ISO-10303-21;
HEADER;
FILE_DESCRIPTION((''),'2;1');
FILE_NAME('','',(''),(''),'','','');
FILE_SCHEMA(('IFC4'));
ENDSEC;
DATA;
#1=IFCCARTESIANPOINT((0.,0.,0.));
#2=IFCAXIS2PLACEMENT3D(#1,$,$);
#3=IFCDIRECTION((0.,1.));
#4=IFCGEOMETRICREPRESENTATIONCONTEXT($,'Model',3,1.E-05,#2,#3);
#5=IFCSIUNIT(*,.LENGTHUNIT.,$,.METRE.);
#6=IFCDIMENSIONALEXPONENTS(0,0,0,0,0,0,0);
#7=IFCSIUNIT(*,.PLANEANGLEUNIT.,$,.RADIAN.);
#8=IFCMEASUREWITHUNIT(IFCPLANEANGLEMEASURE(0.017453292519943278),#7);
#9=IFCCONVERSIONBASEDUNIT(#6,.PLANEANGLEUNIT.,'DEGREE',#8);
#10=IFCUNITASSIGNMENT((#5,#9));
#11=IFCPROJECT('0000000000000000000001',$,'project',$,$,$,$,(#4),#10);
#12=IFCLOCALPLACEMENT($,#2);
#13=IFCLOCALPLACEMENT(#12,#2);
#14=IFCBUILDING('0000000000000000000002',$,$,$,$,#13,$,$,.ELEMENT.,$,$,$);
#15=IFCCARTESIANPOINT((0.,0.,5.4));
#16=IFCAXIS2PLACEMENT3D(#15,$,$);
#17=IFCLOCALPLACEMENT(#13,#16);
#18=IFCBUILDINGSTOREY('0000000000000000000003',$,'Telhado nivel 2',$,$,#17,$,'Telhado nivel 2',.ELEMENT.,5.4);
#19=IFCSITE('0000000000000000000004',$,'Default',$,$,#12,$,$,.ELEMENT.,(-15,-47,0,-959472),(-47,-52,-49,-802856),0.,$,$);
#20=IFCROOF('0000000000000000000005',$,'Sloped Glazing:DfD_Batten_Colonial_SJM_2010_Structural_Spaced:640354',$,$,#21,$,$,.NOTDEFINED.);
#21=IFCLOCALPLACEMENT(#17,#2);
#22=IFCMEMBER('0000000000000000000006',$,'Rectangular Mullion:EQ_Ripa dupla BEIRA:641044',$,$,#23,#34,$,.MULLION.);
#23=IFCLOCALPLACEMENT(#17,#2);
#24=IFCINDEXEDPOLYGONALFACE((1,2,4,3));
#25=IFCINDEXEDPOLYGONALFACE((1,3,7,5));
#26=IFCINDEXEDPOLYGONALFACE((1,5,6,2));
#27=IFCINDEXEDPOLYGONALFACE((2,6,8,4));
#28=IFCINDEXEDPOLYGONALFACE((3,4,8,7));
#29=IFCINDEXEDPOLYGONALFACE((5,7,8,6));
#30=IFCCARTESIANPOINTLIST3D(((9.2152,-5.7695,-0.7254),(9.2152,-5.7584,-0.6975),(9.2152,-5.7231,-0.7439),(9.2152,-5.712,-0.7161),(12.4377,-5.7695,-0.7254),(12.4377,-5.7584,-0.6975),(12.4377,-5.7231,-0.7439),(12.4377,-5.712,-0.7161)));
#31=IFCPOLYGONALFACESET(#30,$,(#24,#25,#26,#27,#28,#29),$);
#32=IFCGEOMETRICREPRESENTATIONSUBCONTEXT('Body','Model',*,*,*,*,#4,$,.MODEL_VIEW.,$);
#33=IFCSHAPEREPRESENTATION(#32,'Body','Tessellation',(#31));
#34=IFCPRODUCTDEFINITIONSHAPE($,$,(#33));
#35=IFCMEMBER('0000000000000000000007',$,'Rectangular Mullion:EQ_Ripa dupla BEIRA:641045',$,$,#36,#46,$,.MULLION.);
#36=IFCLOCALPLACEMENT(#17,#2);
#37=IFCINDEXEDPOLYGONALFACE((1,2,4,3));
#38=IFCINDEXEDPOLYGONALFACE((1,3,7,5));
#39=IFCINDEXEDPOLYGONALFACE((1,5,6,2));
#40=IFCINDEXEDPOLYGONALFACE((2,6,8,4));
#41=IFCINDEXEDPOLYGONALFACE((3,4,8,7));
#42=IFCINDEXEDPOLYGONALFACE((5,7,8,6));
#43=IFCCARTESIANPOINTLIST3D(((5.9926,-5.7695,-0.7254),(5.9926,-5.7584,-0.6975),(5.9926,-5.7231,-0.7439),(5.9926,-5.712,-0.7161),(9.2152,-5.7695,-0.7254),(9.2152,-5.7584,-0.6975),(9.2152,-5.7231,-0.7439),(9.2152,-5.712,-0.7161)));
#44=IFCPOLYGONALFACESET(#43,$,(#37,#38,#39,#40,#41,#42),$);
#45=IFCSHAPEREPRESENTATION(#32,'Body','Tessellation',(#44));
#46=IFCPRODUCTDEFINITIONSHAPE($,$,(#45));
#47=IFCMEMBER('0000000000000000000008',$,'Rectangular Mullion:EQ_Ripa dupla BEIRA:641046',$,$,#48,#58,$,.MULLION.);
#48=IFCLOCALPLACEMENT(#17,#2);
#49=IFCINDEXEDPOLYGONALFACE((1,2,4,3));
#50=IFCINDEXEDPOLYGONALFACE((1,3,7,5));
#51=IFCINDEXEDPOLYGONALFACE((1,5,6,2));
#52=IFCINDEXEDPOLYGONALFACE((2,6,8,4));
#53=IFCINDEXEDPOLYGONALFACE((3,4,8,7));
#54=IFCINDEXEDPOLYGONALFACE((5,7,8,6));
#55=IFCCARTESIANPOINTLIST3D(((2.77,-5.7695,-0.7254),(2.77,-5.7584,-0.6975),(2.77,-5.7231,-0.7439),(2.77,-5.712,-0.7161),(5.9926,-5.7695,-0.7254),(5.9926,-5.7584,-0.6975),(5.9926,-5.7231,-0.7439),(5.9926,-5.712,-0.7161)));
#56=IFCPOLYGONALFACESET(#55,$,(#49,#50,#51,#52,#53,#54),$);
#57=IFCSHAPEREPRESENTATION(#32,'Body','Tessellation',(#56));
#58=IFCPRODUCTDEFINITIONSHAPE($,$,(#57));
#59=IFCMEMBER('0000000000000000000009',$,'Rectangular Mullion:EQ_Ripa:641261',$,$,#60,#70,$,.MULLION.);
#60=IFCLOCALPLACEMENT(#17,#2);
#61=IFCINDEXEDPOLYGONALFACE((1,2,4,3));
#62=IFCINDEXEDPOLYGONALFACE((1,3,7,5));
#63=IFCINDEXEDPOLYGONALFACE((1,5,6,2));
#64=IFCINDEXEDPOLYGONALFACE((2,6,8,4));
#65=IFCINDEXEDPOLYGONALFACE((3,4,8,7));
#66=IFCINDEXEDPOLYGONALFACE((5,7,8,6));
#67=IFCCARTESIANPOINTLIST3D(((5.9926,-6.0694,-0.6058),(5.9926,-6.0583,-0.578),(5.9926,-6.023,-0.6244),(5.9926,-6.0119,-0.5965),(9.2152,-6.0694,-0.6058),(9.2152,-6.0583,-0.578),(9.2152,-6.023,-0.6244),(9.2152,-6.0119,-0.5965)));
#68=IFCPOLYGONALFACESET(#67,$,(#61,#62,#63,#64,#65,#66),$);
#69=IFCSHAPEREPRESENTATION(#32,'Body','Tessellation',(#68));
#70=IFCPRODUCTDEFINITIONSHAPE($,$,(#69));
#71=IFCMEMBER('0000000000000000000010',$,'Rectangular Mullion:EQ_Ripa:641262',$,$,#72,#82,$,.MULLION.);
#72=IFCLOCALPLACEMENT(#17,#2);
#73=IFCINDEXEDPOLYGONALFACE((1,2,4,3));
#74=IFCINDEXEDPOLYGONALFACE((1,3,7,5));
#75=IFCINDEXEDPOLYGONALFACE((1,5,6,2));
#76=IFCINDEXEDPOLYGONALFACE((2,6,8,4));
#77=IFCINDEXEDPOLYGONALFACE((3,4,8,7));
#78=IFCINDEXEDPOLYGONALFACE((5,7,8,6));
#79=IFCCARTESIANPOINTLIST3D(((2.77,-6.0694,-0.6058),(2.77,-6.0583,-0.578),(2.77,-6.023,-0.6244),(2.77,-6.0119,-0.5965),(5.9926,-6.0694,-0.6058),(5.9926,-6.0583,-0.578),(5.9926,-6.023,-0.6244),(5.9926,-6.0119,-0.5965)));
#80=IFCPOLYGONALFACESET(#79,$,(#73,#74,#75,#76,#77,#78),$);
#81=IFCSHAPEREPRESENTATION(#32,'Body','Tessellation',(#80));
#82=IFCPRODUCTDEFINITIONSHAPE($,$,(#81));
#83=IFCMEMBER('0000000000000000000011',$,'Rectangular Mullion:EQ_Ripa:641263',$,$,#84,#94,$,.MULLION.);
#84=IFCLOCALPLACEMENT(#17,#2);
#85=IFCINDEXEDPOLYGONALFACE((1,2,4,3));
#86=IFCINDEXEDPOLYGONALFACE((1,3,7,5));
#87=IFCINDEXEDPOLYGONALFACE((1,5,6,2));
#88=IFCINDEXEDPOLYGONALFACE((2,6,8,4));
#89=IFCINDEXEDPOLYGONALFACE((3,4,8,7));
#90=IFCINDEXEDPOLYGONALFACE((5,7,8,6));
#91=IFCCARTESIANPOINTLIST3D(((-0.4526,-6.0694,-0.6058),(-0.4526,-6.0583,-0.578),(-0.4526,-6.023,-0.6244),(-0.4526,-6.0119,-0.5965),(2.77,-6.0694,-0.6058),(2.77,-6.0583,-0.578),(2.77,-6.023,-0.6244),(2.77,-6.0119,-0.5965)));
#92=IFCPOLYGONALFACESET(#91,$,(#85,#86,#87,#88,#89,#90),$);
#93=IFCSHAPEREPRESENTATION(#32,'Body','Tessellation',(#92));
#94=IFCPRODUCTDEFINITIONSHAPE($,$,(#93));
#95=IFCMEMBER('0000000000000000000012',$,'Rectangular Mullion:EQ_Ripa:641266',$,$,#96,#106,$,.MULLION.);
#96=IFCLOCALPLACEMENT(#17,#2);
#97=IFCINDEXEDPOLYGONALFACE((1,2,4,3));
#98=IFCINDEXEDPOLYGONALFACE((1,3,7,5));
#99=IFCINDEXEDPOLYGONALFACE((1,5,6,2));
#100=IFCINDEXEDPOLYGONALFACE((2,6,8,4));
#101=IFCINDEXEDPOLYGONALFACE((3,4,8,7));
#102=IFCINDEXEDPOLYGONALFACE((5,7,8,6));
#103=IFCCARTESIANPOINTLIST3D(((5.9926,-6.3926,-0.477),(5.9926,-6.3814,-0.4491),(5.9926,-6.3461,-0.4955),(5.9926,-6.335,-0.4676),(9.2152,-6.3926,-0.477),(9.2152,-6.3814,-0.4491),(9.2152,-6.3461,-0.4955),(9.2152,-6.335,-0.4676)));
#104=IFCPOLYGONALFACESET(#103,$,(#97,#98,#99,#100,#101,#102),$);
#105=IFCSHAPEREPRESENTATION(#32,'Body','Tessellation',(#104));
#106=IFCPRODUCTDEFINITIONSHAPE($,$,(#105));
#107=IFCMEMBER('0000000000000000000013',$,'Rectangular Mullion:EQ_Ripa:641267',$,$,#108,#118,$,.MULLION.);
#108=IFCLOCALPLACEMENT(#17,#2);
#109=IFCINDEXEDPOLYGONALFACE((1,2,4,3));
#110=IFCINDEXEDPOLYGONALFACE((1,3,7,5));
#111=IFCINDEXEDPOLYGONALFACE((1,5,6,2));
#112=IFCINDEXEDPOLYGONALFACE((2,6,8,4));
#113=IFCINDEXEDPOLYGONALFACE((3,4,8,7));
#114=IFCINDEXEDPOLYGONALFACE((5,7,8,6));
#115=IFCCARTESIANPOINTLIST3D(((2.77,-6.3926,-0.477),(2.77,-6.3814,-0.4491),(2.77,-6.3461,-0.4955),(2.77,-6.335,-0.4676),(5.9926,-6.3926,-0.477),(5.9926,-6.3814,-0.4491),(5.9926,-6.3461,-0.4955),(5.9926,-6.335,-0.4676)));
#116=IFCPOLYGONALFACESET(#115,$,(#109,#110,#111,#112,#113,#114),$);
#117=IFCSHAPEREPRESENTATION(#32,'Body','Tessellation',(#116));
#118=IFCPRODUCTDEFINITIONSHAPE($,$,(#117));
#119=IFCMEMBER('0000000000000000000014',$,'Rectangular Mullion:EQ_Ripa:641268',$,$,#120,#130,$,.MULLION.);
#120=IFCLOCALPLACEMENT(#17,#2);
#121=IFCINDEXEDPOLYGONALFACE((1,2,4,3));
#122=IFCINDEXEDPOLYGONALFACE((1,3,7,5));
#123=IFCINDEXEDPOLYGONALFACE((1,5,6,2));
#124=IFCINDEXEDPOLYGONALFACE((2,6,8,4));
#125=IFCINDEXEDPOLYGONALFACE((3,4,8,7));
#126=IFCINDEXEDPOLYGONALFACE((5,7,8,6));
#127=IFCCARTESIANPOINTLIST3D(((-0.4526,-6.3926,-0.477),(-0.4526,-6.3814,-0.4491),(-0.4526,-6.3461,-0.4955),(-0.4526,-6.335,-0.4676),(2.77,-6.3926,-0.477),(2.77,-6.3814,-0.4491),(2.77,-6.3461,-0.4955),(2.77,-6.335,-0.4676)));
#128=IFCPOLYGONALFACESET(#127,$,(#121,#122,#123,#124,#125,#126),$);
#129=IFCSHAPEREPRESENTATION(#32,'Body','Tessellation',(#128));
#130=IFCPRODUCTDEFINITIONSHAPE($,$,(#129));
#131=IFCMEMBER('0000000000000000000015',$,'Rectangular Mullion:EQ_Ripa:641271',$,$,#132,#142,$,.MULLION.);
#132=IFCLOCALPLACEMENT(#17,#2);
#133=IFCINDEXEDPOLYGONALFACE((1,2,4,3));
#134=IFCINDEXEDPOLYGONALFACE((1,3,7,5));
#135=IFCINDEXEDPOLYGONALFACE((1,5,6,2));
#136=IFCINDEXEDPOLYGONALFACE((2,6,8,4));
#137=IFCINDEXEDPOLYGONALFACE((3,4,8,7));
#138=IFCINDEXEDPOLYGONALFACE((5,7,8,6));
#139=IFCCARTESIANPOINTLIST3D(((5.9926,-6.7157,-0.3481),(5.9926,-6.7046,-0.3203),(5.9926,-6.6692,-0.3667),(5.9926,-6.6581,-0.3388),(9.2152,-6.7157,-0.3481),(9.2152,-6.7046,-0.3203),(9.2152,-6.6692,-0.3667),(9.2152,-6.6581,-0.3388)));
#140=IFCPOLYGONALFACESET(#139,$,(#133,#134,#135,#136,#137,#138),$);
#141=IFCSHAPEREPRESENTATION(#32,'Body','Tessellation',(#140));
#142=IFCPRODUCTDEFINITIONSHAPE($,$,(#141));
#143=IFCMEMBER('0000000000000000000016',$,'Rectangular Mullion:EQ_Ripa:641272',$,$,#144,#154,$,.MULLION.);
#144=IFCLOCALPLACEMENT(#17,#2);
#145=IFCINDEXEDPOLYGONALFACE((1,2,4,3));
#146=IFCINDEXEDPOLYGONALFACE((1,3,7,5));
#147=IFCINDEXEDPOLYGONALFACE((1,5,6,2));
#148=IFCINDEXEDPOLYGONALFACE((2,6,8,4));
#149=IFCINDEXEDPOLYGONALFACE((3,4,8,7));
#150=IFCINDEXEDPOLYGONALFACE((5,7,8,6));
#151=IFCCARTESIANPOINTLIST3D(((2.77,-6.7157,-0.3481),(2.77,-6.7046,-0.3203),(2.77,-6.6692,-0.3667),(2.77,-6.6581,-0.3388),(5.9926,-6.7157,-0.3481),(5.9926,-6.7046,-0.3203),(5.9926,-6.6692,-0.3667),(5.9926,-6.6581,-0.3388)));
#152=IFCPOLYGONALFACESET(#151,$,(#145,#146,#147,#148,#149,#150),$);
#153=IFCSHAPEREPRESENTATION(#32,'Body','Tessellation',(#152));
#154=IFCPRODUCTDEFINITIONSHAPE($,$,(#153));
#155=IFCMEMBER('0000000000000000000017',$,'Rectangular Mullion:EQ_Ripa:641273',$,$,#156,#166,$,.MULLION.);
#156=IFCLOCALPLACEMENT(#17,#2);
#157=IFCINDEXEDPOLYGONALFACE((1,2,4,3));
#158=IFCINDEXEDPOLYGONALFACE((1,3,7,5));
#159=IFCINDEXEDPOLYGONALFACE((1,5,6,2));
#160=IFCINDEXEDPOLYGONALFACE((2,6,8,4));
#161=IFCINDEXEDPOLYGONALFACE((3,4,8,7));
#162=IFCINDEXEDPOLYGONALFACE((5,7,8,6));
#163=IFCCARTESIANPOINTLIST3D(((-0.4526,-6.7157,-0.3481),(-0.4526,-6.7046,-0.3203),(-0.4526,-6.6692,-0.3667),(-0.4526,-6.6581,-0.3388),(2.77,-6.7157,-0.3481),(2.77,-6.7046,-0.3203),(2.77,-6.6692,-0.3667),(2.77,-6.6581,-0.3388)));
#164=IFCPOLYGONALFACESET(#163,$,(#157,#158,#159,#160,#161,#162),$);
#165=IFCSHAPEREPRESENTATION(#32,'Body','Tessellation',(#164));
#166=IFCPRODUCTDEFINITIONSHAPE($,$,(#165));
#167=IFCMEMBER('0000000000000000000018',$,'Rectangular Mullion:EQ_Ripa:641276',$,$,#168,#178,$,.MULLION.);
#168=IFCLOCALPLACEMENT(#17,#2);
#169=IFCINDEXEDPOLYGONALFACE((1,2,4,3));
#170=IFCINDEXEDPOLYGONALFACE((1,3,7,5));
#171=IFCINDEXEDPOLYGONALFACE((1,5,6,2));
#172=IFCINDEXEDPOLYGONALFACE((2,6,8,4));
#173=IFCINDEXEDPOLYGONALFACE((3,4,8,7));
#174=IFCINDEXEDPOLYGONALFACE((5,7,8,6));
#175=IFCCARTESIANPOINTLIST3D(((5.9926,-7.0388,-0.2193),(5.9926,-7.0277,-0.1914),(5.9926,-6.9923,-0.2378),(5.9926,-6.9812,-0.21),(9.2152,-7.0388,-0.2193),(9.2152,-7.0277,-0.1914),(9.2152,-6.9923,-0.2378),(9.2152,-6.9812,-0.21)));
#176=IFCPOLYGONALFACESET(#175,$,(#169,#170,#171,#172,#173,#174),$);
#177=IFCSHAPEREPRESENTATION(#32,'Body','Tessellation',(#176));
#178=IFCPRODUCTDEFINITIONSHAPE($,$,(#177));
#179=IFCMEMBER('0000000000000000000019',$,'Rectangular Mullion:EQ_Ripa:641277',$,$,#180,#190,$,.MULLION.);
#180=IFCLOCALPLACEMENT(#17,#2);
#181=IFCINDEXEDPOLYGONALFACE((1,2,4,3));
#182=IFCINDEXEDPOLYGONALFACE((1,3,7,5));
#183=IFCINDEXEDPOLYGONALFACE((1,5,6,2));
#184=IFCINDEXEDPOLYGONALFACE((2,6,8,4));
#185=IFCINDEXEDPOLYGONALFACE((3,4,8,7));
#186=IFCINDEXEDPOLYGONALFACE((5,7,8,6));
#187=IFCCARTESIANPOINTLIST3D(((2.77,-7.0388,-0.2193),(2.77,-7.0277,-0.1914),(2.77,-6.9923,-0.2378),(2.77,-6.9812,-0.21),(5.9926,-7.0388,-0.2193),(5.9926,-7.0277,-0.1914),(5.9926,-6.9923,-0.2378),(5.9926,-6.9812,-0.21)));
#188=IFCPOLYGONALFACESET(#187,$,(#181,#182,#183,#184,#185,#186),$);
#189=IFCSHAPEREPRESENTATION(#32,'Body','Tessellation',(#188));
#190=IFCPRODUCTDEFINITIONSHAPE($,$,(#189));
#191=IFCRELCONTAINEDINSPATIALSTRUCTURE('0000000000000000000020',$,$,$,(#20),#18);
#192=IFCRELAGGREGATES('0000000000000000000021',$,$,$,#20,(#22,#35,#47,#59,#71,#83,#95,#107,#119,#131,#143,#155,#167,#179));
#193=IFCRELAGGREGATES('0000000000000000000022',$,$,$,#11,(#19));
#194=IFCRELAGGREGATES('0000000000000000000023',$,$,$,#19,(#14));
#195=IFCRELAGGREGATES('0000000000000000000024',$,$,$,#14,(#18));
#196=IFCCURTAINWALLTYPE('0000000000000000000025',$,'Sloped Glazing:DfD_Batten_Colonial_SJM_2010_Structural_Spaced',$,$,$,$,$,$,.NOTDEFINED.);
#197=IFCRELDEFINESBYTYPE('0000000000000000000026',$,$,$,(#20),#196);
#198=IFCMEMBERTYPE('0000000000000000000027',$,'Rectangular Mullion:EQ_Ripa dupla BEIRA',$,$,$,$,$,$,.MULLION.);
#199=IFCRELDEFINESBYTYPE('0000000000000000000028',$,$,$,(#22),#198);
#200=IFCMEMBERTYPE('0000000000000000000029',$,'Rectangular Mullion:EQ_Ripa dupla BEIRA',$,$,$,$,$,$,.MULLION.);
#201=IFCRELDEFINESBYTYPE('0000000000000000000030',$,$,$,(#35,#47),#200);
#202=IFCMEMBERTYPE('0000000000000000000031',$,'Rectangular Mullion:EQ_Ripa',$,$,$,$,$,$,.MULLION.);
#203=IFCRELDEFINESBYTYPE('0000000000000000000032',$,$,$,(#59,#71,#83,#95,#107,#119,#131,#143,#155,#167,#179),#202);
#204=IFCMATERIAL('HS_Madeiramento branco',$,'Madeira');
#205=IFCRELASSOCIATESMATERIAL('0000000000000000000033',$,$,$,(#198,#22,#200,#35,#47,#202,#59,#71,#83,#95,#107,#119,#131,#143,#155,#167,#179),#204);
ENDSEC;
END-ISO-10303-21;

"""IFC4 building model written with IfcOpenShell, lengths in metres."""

from ifc_helpers import new_model, entity, si_unit, converted_unit, direction, frame, origin, place, context, subcontext, project, spatial, indexed_curve, outline, extrude, source, transform, mapped, material, type_object, type_shapes, element, aggregate, save


model = new_model("IFC4")

# Units and contexts
model_context = context("Model", 3, precision=1e-05, world=origin(), true_north=direction((0.0, 1.0)))
body_context = subcontext(model_context, "Body", "Model", "MODEL_VIEW")
ifc_project = project(units=[si_unit("LENGTHUNIT", "METRE"), converted_unit("PLANEANGLEUNIT", "DEGREE", entity("IfcPlaneAngleMeasure", 0.017453292519943278), si_unit("PLANEANGLEUNIT", "RADIAN"), dimensions=[0, 0, 0, 0, 0, 0, 0])], contexts=[model_context])

# Site, building, storey
site_placement = place(None, origin())
site = spatial("IfcSite", under=ifc_project, at=site_placement, Name="Default", CompositionType="ELEMENT", RefLatitude=(-15, -47, 0, -959472), RefLongitude=(-47, -52, -49, -802856), RefElevation=0.0)
building_placement = place(site_placement, origin())
building = spatial("IfcBuilding", under=site, at=building_placement, CompositionType="ELEMENT")
storey_placement = place(building_placement, frame((0.0, 0.0, 5.4)))
storey = spatial("IfcBuildingStorey", under=building, at=storey_placement, Name="Telhado nivel 2", LongName="Telhado nivel 2", CompositionType="ELEMENT", Elevation=5.4)

# Roof, members
curtain_wall_type = type_object("IfcCurtainWallType", Name="Sloped Glazing:DfD_Batten_Colonial_SJM_2010_Structural_Spaced", PredefinedType="NOTDEFINED")
roof_placement = place(storey_placement, frame((0.0, 0.0, -5.4)))
roof = element("IfcRoof", 1, at=roof_placement, inside=storey, type_object=curtain_wall_type, Name="Sloped Glazing:DfD_Batten_Colonial_SJM_2010_Structural_Spaced:640354", PredefinedType="NOTDEFINED")
ifc_material = material(Name="HS_Madeiramento branco", Category="Madeira")
member_type_1 = type_object("IfcMemberType", Name="Rectangular Mullion:EQ_Ripa dupla BEIRA", PredefinedType="MULLION", material=ifc_material)
shared_shape_1 = source(origin(), body_context, "Body", "SweptSolid", [
    extrude(outline(indexed_curve([(-0.025, -0.015), (0.025, -0.015), (0.025, 0.015), (-0.025, 0.015), (-0.025, -0.015)], self_intersect=False)), frame((-0.025, 0.0, -3.2226), z_axis=(0.0, 0.0, 1.0), x_axis=(-1.0, 0.0, 0.0)), (0.0, 0.0, 1.0), 3.2226),
])
type_shapes(member_type_1, [shared_shape_1])
member_1_placement = place(roof_placement, frame((9.2152, -5.7175, 4.67), z_axis=(-1.0, 0.0, 0.0), x_axis=(0.0, 0.928878, -0.370385)))
member_1 = element("IfcMember", 2, at=member_1_placement, type_object=member_type_1, material=ifc_material, Name="Rectangular Mullion:EQ_Ripa dupla BEIRA:641044", PredefinedType="MULLION", context=body_context, shape_type="MappedRepresentation", body=[
    mapped(shared_shape_1, transform((0.0, 0.0, 0.0), scale=1.0)),
])
member_type_2 = type_object("IfcMemberType", Name="Rectangular Mullion:EQ_Ripa dupla BEIRA", PredefinedType="MULLION", material=ifc_material)
shared_shape_2 = source(origin(), body_context, "Body", "SweptSolid", [
    extrude(outline(indexed_curve([(-0.025, -0.015), (0.025, -0.015), (0.025, 0.015), (-0.025, 0.015), (-0.025, -0.015)], self_intersect=False)), frame((-0.025, 0.0, -3.2226), z_axis=(0.0, 0.0, 1.0), x_axis=(-1.0, 0.0, 0.0)), (0.0, 0.0, 1.0), 3.2226),
])
type_shapes(member_type_2, [shared_shape_2])
member_2_placement = place(roof_placement, frame((5.9926, -5.7175, 4.67), z_axis=(-1.0, 0.0, 0.0), x_axis=(0.0, 0.928878, -0.370385)))
member_2 = element("IfcMember", 3, at=member_2_placement, type_object=member_type_2, material=ifc_material, Name="Rectangular Mullion:EQ_Ripa dupla BEIRA:641045", PredefinedType="MULLION", context=body_context, shape_type="MappedRepresentation", body=[
    mapped(shared_shape_2, transform((0.0, 0.0, 0.0), scale=1.0)),
])
member_3_placement = place(roof_placement, frame((2.77, -5.7175, 4.67), z_axis=(-1.0, 0.0, 0.0), x_axis=(0.0, 0.928878, -0.370385)))
member_3 = element("IfcMember", 4, at=member_3_placement, type_object=member_type_2, material=ifc_material, Name="Rectangular Mullion:EQ_Ripa dupla BEIRA:641046", PredefinedType="MULLION", context=body_context, shape_type="MappedRepresentation", body=[
    mapped(shared_shape_2, transform((0.0, 0.0, 0.0), scale=1.0)),
])
member_type_3 = type_object("IfcMemberType", Name="Rectangular Mullion:EQ_Ripa", PredefinedType="MULLION", material=ifc_material)
shared_shape_3 = source(origin(), body_context, "Body", "SweptSolid", [
    extrude(outline(indexed_curve([(-0.025, -0.015), (0.025, -0.015), (0.025, 0.015), (-0.025, 0.015), (-0.025, -0.015)], self_intersect=False)), frame((0.0, 0.0, -3.2226), z_axis=(0.0, 0.0, 1.0), x_axis=(-1.0, 0.0, 0.0)), (0.0, 0.0, 1.0), 3.2226),
])
type_shapes(member_type_3, [shared_shape_3])
member_4_placement = place(roof_placement, frame((9.2152, -6.0407, 4.7988), z_axis=(1.0, 0.0, 0.0), x_axis=(0.0, -0.928878, 0.370385)))
member_4 = element("IfcMember", 5, at=member_4_placement, type_object=member_type_3, material=ifc_material, Name="Rectangular Mullion:EQ_Ripa:641261", PredefinedType="MULLION", context=body_context, shape_type="MappedRepresentation", body=[
    mapped(shared_shape_3, transform((0.0, 0.0, 0.0), scale=1.0)),
])
member_5_placement = place(roof_placement, frame((5.9926, -6.0407, 4.7988), z_axis=(1.0, 0.0, 0.0), x_axis=(0.0, -0.928878, 0.370385)))
member_5 = element("IfcMember", 6, at=member_5_placement, type_object=member_type_3, material=ifc_material, Name="Rectangular Mullion:EQ_Ripa:641262", PredefinedType="MULLION", context=body_context, shape_type="MappedRepresentation", body=[
    mapped(shared_shape_3, transform((0.0, 0.0, 0.0), scale=1.0)),
])
member_6_placement = place(roof_placement, frame((2.77, -6.0407, 4.7988), z_axis=(1.0, 0.0, 0.0), x_axis=(0.0, -0.928878, 0.370385)))
member_6 = element("IfcMember", 7, at=member_6_placement, type_object=member_type_3, material=ifc_material, Name="Rectangular Mullion:EQ_Ripa:641263", PredefinedType="MULLION", context=body_context, shape_type="MappedRepresentation", body=[
    mapped(shared_shape_3, transform((0.0, 0.0, 0.0), scale=1.0)),
])
member_7_placement = place(roof_placement, frame((9.2152, -6.3638, 4.9277), z_axis=(1.0, 0.0, 0.0), x_axis=(0.0, -0.928878, 0.370385)))
member_7 = element("IfcMember", 8, at=member_7_placement, type_object=member_type_3, material=ifc_material, Name="Rectangular Mullion:EQ_Ripa:641266", PredefinedType="MULLION", context=body_context, shape_type="MappedRepresentation", body=[
    mapped(shared_shape_3, transform((0.0, 0.0, 0.0), scale=1.0)),
])
member_8_placement = place(roof_placement, frame((5.9926, -6.3638, 4.9277), z_axis=(1.0, 0.0, 0.0), x_axis=(0.0, -0.928878, 0.370385)))
member_8 = element("IfcMember", 9, at=member_8_placement, type_object=member_type_3, material=ifc_material, Name="Rectangular Mullion:EQ_Ripa:641267", PredefinedType="MULLION", context=body_context, shape_type="MappedRepresentation", body=[
    mapped(shared_shape_3, transform((0.0, 0.0, 0.0), scale=1.0)),
])
member_9_placement = place(roof_placement, frame((2.77, -6.3638, 4.9277), z_axis=(1.0, 0.0, 0.0), x_axis=(0.0, -0.928878, 0.370385)))
member_9 = element("IfcMember", 10, at=member_9_placement, type_object=member_type_3, material=ifc_material, Name="Rectangular Mullion:EQ_Ripa:641268", PredefinedType="MULLION", context=body_context, shape_type="MappedRepresentation", body=[
    mapped(shared_shape_3, transform((0.0, 0.0, 0.0), scale=1.0)),
])
member_10_placement = place(roof_placement, frame((9.2152, -6.6869, 5.0565), z_axis=(1.0, 0.0, 0.0), x_axis=(0.0, -0.928878, 0.370385)))
member_10 = element("IfcMember", 11, at=member_10_placement, type_object=member_type_3, material=ifc_material, Name="Rectangular Mullion:EQ_Ripa:641271", PredefinedType="MULLION", context=body_context, shape_type="MappedRepresentation", body=[
    mapped(shared_shape_3, transform((0.0, 0.0, 0.0), scale=1.0)),
])
member_11_placement = place(roof_placement, frame((5.9926, -6.6869, 5.0565), z_axis=(1.0, 0.0, 0.0), x_axis=(0.0, -0.928878, 0.370385)))
member_11 = element("IfcMember", 12, at=member_11_placement, type_object=member_type_3, material=ifc_material, Name="Rectangular Mullion:EQ_Ripa:641272", PredefinedType="MULLION", context=body_context, shape_type="MappedRepresentation", body=[
    mapped(shared_shape_3, transform((0.0, 0.0, 0.0), scale=1.0)),
])
member_12_placement = place(roof_placement, frame((2.77, -6.6869, 5.0565), z_axis=(1.0, 0.0, 0.0), x_axis=(0.0, -0.928878, 0.370385)))
member_12 = element("IfcMember", 13, at=member_12_placement, type_object=member_type_3, material=ifc_material, Name="Rectangular Mullion:EQ_Ripa:641273", PredefinedType="MULLION", context=body_context, shape_type="MappedRepresentation", body=[
    mapped(shared_shape_3, transform((0.0, 0.0, 0.0), scale=1.0)),
])
member_13_placement = place(roof_placement, frame((9.2152, -7.01, 5.1854), z_axis=(1.0, 0.0, 0.0), x_axis=(0.0, -0.928878, 0.370385)))
member_13 = element("IfcMember", 14, at=member_13_placement, type_object=member_type_3, material=ifc_material, Name="Rectangular Mullion:EQ_Ripa:641276", PredefinedType="MULLION", context=body_context, shape_type="MappedRepresentation", body=[
    mapped(shared_shape_3, transform((0.0, 0.0, 0.0), scale=1.0)),
])
member_14_placement = place(roof_placement, frame((5.9926, -7.01, 5.1854), z_axis=(1.0, 0.0, 0.0), x_axis=(0.0, -0.928878, 0.370385)))
member_14 = element("IfcMember", 15, at=member_14_placement, type_object=member_type_3, material=ifc_material, Name="Rectangular Mullion:EQ_Ripa:641277", PredefinedType="MULLION", context=body_context, shape_type="MappedRepresentation", body=[
    mapped(shared_shape_3, transform((0.0, 0.0, 0.0), scale=1.0)),
])
aggregate(roof, [member_1, member_2, member_3, member_4, member_5, member_6, member_7, member_8, member_9, member_10, member_11, member_12, member_13, member_14])

save(model, "model.ifc")
